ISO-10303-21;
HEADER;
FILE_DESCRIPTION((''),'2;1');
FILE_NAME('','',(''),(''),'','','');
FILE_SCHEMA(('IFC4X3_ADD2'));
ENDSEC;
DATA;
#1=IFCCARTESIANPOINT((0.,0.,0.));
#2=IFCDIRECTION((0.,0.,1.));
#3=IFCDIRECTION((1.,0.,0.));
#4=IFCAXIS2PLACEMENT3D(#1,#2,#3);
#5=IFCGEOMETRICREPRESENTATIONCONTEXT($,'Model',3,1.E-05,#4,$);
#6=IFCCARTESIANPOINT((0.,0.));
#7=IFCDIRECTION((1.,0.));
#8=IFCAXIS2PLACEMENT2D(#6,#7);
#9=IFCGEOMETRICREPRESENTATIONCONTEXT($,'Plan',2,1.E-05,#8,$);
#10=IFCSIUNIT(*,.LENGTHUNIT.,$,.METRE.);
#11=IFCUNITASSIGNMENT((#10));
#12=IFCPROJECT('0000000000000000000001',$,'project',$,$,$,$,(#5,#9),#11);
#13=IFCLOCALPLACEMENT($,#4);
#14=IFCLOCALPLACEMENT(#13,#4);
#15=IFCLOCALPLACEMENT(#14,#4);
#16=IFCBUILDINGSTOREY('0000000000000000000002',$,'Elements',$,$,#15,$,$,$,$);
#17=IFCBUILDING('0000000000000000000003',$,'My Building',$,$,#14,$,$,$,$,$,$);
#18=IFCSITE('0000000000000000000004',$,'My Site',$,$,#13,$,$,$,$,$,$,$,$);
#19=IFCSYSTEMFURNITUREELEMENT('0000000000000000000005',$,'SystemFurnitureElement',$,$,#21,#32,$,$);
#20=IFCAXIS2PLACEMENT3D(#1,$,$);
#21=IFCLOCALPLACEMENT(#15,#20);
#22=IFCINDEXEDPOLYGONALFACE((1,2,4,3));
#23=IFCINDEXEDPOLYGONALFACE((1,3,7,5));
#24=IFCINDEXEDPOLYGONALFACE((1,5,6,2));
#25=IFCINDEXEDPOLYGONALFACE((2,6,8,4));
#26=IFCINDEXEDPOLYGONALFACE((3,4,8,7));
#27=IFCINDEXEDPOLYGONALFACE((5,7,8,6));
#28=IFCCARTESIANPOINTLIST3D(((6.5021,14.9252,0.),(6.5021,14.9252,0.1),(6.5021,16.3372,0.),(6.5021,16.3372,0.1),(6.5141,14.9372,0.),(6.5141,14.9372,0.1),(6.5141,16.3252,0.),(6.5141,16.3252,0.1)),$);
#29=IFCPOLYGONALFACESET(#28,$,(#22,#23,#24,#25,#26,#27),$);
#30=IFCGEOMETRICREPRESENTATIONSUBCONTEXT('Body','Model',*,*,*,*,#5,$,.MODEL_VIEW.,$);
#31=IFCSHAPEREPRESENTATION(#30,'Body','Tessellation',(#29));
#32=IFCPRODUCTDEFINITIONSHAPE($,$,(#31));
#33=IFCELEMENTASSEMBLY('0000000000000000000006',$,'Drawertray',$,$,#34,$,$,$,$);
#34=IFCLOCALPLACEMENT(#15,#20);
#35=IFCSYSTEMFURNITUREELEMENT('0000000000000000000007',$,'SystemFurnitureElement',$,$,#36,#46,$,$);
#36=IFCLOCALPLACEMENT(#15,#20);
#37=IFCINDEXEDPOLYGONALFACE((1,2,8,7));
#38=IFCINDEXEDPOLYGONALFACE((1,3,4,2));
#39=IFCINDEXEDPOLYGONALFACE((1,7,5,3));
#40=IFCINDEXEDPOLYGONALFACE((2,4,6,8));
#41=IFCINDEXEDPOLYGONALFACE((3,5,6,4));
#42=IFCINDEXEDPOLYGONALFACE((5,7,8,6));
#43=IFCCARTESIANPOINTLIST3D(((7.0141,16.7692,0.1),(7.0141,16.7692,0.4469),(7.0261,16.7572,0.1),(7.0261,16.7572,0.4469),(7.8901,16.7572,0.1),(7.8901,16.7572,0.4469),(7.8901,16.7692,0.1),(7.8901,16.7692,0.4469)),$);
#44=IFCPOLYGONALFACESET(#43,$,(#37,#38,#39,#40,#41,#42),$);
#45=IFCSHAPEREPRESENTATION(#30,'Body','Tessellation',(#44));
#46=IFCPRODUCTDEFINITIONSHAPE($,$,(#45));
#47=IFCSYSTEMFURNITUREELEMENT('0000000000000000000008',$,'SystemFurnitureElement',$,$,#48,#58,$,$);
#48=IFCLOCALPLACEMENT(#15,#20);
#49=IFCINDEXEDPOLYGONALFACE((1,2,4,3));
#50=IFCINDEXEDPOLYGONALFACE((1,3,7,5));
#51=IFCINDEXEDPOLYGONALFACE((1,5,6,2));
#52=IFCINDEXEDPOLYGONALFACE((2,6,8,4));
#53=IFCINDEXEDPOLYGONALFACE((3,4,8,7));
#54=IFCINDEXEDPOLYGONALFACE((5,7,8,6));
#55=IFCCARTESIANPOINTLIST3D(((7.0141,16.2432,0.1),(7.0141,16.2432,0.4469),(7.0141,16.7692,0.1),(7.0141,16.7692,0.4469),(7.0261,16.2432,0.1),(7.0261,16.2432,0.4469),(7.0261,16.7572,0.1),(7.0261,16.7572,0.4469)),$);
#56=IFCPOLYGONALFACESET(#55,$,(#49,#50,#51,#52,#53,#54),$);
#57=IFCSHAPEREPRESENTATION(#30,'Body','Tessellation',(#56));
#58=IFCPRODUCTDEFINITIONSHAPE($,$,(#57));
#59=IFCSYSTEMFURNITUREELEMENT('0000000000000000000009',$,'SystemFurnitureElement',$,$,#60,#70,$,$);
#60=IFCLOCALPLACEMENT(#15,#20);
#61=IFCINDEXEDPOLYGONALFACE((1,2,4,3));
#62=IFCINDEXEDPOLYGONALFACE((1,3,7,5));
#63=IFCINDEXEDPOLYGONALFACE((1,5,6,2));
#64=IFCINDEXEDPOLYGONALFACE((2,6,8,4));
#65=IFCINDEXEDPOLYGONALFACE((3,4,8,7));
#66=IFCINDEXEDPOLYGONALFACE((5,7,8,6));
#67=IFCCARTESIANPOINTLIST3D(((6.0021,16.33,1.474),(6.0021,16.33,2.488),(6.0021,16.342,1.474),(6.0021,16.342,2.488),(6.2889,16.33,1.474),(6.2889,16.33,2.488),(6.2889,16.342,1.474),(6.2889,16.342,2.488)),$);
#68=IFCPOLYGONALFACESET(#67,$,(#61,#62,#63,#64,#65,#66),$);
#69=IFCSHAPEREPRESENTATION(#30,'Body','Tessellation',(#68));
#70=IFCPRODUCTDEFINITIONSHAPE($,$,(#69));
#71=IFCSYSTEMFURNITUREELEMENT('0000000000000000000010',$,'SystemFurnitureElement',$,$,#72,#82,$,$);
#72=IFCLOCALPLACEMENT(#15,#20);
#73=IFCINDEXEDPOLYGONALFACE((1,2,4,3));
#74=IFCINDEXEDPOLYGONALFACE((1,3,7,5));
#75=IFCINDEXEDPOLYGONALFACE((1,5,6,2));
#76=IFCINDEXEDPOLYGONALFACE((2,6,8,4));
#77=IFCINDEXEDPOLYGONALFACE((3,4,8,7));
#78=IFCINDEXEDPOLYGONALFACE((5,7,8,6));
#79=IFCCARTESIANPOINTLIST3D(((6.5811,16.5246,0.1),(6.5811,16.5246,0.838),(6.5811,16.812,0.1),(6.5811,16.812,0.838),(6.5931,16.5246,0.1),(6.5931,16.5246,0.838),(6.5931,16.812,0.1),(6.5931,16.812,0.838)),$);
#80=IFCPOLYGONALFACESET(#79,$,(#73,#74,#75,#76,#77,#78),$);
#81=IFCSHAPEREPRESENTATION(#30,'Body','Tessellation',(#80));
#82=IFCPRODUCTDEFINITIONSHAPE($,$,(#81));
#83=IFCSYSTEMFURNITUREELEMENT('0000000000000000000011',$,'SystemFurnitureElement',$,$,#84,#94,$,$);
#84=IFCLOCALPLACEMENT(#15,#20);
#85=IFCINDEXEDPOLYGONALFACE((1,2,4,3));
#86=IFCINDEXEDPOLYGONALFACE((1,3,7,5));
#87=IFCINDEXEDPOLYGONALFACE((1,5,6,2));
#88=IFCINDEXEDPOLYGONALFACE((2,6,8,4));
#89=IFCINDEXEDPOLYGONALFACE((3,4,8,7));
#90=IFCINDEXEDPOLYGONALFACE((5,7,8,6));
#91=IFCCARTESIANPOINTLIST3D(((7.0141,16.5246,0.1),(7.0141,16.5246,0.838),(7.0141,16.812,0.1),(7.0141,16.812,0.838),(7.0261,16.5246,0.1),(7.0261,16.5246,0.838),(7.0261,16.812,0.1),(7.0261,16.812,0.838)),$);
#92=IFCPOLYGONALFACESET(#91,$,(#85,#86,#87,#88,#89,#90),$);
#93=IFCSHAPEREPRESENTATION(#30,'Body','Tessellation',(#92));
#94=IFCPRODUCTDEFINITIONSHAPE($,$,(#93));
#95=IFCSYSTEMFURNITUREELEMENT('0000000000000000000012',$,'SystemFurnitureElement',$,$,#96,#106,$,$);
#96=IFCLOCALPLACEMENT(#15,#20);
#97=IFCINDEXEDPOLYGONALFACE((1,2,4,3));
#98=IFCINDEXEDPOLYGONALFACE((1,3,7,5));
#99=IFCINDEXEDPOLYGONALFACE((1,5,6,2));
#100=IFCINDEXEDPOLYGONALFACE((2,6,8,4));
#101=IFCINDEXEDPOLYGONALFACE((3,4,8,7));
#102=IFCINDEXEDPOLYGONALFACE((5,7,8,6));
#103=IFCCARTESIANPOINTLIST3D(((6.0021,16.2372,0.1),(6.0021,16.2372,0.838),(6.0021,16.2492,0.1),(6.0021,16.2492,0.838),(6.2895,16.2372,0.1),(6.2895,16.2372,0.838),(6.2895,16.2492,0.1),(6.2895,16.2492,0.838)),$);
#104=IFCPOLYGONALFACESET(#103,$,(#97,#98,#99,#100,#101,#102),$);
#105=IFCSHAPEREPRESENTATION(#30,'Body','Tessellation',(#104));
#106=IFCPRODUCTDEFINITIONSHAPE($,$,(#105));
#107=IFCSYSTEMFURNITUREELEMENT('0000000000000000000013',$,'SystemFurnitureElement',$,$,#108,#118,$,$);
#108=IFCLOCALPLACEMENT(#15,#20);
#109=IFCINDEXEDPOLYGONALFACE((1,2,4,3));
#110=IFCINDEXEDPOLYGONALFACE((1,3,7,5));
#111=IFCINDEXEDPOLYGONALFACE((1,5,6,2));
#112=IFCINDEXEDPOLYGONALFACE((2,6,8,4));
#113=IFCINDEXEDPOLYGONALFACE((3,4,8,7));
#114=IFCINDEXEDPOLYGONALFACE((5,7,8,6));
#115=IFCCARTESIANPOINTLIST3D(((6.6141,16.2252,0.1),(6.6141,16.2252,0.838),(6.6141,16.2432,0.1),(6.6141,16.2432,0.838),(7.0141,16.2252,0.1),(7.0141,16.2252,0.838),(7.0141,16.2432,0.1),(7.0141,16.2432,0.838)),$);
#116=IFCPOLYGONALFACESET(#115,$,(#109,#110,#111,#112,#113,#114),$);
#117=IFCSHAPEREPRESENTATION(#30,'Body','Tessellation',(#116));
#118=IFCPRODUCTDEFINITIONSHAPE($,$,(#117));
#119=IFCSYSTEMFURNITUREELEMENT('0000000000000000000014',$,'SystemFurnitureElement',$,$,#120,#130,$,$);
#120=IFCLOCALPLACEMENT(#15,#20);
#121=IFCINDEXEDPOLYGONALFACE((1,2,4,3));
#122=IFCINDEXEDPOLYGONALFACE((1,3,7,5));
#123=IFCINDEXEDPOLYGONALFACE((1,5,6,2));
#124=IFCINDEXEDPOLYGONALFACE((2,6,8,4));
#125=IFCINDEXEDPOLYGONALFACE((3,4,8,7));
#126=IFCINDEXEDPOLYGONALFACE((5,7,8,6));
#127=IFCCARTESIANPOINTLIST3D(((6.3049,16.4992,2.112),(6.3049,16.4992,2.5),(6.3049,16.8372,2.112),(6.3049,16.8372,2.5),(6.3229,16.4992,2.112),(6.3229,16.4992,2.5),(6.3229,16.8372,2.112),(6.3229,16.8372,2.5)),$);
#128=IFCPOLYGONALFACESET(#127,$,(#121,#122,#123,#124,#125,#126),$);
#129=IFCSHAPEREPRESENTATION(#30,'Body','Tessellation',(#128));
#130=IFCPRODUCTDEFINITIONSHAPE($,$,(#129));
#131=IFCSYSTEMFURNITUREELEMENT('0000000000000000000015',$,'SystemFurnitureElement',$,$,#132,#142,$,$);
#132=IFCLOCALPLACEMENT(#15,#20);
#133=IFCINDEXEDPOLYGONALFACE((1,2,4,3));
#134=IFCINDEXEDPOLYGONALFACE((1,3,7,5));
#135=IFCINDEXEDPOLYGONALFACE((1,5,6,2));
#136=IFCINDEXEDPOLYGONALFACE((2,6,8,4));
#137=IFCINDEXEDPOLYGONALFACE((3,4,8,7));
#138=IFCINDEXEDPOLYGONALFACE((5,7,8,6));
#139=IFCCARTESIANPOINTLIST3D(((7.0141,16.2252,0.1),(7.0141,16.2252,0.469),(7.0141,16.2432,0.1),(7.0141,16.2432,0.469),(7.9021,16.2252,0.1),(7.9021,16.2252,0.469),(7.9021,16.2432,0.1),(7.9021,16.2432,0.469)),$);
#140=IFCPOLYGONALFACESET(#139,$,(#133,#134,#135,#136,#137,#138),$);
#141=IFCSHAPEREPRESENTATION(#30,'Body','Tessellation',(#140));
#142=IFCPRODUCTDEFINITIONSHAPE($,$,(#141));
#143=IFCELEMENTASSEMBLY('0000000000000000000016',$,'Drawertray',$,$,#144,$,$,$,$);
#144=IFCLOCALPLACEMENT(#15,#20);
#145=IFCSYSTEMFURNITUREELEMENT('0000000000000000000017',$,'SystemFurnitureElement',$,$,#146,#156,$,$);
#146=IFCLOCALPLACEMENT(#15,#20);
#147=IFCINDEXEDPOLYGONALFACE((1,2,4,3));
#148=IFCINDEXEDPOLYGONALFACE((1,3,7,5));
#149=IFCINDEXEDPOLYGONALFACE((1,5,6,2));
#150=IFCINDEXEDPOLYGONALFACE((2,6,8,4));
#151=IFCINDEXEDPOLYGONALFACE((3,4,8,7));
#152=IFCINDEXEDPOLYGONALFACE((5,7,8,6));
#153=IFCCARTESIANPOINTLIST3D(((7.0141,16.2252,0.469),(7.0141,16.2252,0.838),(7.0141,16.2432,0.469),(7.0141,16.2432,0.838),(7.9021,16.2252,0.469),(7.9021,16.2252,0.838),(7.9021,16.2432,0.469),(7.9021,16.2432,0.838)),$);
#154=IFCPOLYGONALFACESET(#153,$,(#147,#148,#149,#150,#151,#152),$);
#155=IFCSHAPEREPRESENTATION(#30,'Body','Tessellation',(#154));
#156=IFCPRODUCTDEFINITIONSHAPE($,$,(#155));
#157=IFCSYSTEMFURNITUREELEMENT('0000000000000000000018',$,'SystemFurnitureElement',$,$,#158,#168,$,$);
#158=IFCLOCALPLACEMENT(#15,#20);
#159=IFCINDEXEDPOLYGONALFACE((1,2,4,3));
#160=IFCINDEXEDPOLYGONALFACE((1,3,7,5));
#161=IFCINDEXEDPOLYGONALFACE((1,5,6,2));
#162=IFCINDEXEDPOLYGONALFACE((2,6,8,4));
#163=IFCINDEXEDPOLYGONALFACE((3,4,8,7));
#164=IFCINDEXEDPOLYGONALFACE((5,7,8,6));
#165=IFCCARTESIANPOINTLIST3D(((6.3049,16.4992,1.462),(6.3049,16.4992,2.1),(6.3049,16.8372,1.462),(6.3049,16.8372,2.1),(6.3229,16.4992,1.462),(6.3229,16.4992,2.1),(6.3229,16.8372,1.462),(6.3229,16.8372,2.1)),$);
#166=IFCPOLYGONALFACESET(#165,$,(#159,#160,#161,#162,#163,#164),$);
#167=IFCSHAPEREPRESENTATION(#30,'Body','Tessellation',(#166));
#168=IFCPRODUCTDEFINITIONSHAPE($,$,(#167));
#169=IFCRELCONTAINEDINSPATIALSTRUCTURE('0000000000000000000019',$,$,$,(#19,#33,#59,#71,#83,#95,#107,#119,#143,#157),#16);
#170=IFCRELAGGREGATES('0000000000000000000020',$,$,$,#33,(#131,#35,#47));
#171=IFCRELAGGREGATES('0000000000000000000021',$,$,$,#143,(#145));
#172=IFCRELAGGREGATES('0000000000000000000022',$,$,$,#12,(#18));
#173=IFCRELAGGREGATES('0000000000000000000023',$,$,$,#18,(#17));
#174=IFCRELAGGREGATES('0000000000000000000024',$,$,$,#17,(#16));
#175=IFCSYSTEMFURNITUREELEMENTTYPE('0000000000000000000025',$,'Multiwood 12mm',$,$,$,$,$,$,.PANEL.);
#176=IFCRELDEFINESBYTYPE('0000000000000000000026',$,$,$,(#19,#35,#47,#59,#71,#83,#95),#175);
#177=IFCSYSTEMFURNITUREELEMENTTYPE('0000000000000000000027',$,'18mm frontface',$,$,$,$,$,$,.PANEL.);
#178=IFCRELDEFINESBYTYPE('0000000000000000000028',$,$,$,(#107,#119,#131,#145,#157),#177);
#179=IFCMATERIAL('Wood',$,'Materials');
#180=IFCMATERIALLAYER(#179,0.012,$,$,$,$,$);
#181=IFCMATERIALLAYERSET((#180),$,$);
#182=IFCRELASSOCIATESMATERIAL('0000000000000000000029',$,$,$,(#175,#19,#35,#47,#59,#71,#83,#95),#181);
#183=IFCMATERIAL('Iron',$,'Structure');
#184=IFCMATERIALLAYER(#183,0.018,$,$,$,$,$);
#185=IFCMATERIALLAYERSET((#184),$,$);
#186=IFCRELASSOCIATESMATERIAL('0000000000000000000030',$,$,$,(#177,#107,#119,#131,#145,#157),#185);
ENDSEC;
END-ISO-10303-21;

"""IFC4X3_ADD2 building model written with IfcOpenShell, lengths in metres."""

from ifc_helpers import new_model, si_unit, frame, origin_with_axes, origin_2d_with_axis, place, context, subcontext, project, spatial, line, indexed_curve, outline, extrude, material, layer, layer_set, layer_usage, type_object, element, aggregate, save


model = new_model("IFC4X3_ADD2")

# Units and contexts
model_context = context("Model", 3, precision=1e-05, world=origin_with_axes())
plan_context = context("Plan", 2, precision=1e-05, world=origin_2d_with_axis())
body_context = subcontext(model_context, "Body", "Model", "MODEL_VIEW")
ifc_project = project(units=[si_unit("LENGTHUNIT", "METRE")], contexts=[model_context, plan_context])

# Site, building, storey
site_placement = place(None, origin_with_axes())
site = spatial("IfcSite", under=ifc_project, at=site_placement, Name="My Site")
building_placement = place(site_placement, origin_with_axes())
building = spatial("IfcBuilding", under=site, at=building_placement, Name="My Building")
storey_placement = place(building_placement, origin_with_axes())
storey = spatial("IfcBuildingStorey", under=building, at=storey_placement, Name="Elements")

# System furniture element
ifc_material_1 = material(Name="Wood", Category="Materials")
ifc_layer_1 = layer(ifc_material_1, 0.012)
ifc_layer_set_1 = layer_set([ifc_layer_1])
ifc_layer_usage_1 = layer_usage(ifc_layer_set_1, "AXIS2", "POSITIVE", 0.0)
system_furniture_element_type_1 = type_object("IfcSystemFurnitureElementType", Name="Multiwood 12mm", PredefinedType="PANEL", material=ifc_layer_set_1)
system_furniture_element_1_placement = place(storey_placement, frame((6.5021, 16.3372, 0.0), z_axis=(0.0, 0.0, 1.0), x_axis=(0.0, -1.0, 0.0)))
element("IfcSystemFurnitureElement", 1, at=system_furniture_element_1_placement, inside=storey, type_object=system_furniture_element_type_1, material=ifc_layer_usage_1, Name="SystemFurnitureElement", context=body_context, shape_type="SweptSolid", body=[
    extrude(outline(indexed_curve([(0.0, 0.0), (0.012, 0.012), (1.4, 0.012), (1.412, 0.0)], segments=[line(1, 2, 3, 4, 1)])), origin_with_axes(), (0.0, 0.0, 1.0), 0.1),
])

# Element assembly, system furniture elements
assembly_1_placement = place(storey_placement, frame((7.0141, 16.2252, 0.1), z_axis=(0.0, 0.0, 1.0), x_axis=(-1.0, 0.0, 0.0)))
assembly_1 = element("IfcElementAssembly", 2, at=assembly_1_placement, inside=storey, Name="Drawertray")
ifc_layer_usage_2 = layer_usage(ifc_layer_set_1, "AXIS2", "POSITIVE", 0.0)
system_furniture_element_2_placement = place(assembly_1_placement, frame((0.0, -0.532, 0.0), z_axis=(0.0, 0.0, 1.0), x_axis=(-1.0, 0.0, 0.0)))
system_furniture_element_2 = element("IfcSystemFurnitureElement", 3, at=system_furniture_element_2_placement, type_object=system_furniture_element_type_1, material=ifc_layer_usage_2, Name="SystemFurnitureElement", context=body_context, shape_type="SweptSolid", body=[
    extrude(outline(indexed_curve([(0.012, 0.0), (0.0, 0.012), (0.876, 0.012), (0.876, 0.0)], segments=[line(1, 2, 3, 4, 1)])), origin_with_axes(), (0.0, 0.0, 1.0), 0.3469),
])
ifc_layer_usage_3 = layer_usage(ifc_layer_set_1, "AXIS2", "POSITIVE", 0.0)
system_furniture_element_3_placement = place(assembly_1_placement, frame((0.0, -0.532, 0.0), z_axis=(0.0, 0.0, 1.0), x_axis=(0.000001, 1.0, 0.0)))
system_furniture_element_3 = element("IfcSystemFurnitureElement", 4, at=system_furniture_element_3_placement, type_object=system_furniture_element_type_1, material=ifc_layer_usage_3, Name="SystemFurnitureElement", context=body_context, shape_type="SweptSolid", body=[
    extrude(outline(indexed_curve([(-0.012, 0.0), (0.0, 0.012), (0.514, 0.012), (0.514, 0.0)], segments=[line(1, 2, 3, 4, 1)])), origin_with_axes(), (0.0, 0.0, 1.0), 0.3469),
])

# System furniture elements
ifc_layer_usage_4 = layer_usage(ifc_layer_set_1, "AXIS2", "NEGATIVE", 0.0)
system_furniture_element_4_placement = place(storey_placement, frame((6.2889, 16.33, 1.474), z_axis=(0.0, 0.0, 1.0), x_axis=(-1.0, 0.0, 0.0)))
element("IfcSystemFurnitureElement", 5, at=system_furniture_element_4_placement, inside=storey, type_object=system_furniture_element_type_1, material=ifc_layer_usage_4, Name="SystemFurnitureElement", context=body_context, shape_type="SweptSolid", body=[
    extrude(outline(indexed_curve([(0.0, -0.012), (0.0, 0.0), (0.2869, 0.0), (0.2869, -0.012)], segments=[line(1, 2, 3, 4, 1)])), origin_with_axes(), (0.0, 0.0, 1.0), 1.014),
])
ifc_layer_usage_5 = layer_usage(ifc_layer_set_1, "AXIS2", "POSITIVE", 0.0)
system_furniture_element_5_placement = place(storey_placement, frame((6.5811, 16.812, 0.1), z_axis=(0.0, 0.0, 1.0), x_axis=(0.0, -1.0, 0.0)))
element("IfcSystemFurnitureElement", 6, at=system_furniture_element_5_placement, inside=storey, type_object=system_furniture_element_type_1, material=ifc_layer_usage_5, Name="SystemFurnitureElement", context=body_context, shape_type="SweptSolid", body=[
    extrude(outline(indexed_curve([(0.0, 0.0), (0.0, 0.012), (0.2874, 0.012), (0.2874, 0.0)], segments=[line(1, 2, 3, 4, 1)])), origin_with_axes(), (0.0, 0.0, 1.0), 0.738),
])
ifc_layer_usage_6 = layer_usage(ifc_layer_set_1, "AXIS2", "POSITIVE", 0.0)
system_furniture_element_6_placement = place(storey_placement, frame((7.0141, 16.812, 0.1), z_axis=(0.0, 0.0, 1.0), x_axis=(0.0, -1.0, 0.0)))
element("IfcSystemFurnitureElement", 7, at=system_furniture_element_6_placement, inside=storey, type_object=system_furniture_element_type_1, material=ifc_layer_usage_6, Name="SystemFurnitureElement", context=body_context, shape_type="SweptSolid", body=[
    extrude(outline(indexed_curve([(0.0, 0.0), (0.0, 0.012), (0.2874, 0.012), (0.2874, 0.0)], segments=[line(1, 2, 3, 4, 1)])), origin_with_axes(), (0.0, 0.0, 1.0), 0.738),
])
ifc_layer_usage_7 = layer_usage(ifc_layer_set_1, "AXIS2", "POSITIVE", 0.0)
system_furniture_element_7_placement = place(storey_placement, frame((6.0021, 16.2372, 0.1), z_axis=(0.0, 0.0, 1.0), x_axis=(1.0, 0.0, 0.0)))
element("IfcSystemFurnitureElement", 8, at=system_furniture_element_7_placement, inside=storey, type_object=system_furniture_element_type_1, material=ifc_layer_usage_7, Name="SystemFurnitureElement", context=body_context, shape_type="SweptSolid", body=[
    extrude(outline(indexed_curve([(0.0, 0.0), (0.0, 0.012), (0.2874, 0.012), (0.2874, 0.0)], segments=[line(1, 2, 3, 4, 1)])), origin_with_axes(), (0.0, 0.0, 1.0), 0.738),
])
ifc_material_2 = material(Name="Iron", Category="Structure")
ifc_layer_2 = layer(ifc_material_2, 0.018)
ifc_layer_set_2 = layer_set([ifc_layer_2])
ifc_layer_usage_8 = layer_usage(ifc_layer_set_2, "AXIS2", "POSITIVE", 0.0)
system_furniture_element_type_2 = type_object("IfcSystemFurnitureElementType", Name="18mm frontface", PredefinedType="PANEL", material=ifc_layer_set_2)
system_furniture_element_8_placement = place(storey_placement, frame((7.0141, 16.2432, 0.1), z_axis=(0.0, 0.0, 1.0), x_axis=(-1.0, 0.0, 0.0)))
element("IfcSystemFurnitureElement", 9, at=system_furniture_element_8_placement, inside=storey, type_object=system_furniture_element_type_2, material=ifc_layer_usage_8, Name="SystemFurnitureElement", context=body_context, shape_type="SweptSolid", body=[
    extrude(outline(indexed_curve([(0.0, 0.0), (0.0, 0.018), (0.4, 0.018), (0.4, 0.0)], segments=[line(1, 2, 3, 4, 1)])), origin_with_axes(), (0.0, 0.0, 1.0), 0.738),
])
ifc_layer_usage_9 = layer_usage(ifc_layer_set_2, "AXIS2", "POSITIVE", 0.0)
system_furniture_element_9_placement = place(storey_placement, frame((6.3049, 16.8372, 2.112), z_axis=(0.0, 0.0, 1.0), x_axis=(0.0, -1.0, 0.0)))
element("IfcSystemFurnitureElement", 10, at=system_furniture_element_9_placement, inside=storey, type_object=system_furniture_element_type_2, material=ifc_layer_usage_9, Name="SystemFurnitureElement", context=body_context, shape_type="SweptSolid", body=[
    extrude(outline(indexed_curve([(0.0, 0.0), (0.0, 0.018), (0.338, 0.018), (0.338, 0.0)], segments=[line(1, 2, 3, 4, 1)])), origin_with_axes(), (0.0, 0.0, 1.0), 0.388),
])

# System furniture element
ifc_layer_usage_10 = layer_usage(ifc_layer_set_2, "AXIS2", "POSITIVE", 0.0)
system_furniture_element_10_placement = place(assembly_1_placement, frame((0.0, 0.0, 0.0), z_axis=(0.0, 0.0, 1.0), x_axis=(-1.0, 0.0, 0.0)))
system_furniture_element_10 = element("IfcSystemFurnitureElement", 11, at=system_furniture_element_10_placement, type_object=system_furniture_element_type_2, material=ifc_layer_usage_10, Name="SystemFurnitureElement", context=body_context, shape_type="SweptSolid", body=[
    extrude(outline(indexed_curve([(0.0, 0.0), (0.0, 0.018), (0.888, 0.018), (0.888, 0.0)], segments=[line(1, 2, 3, 4, 1)])), origin_with_axes(), (0.0, 0.0, 1.0), 0.369),
])
aggregate(assembly_1, [system_furniture_element_10, system_furniture_element_2, system_furniture_element_3])

# Element assembly, system furniture element
assembly_2_placement = place(storey_placement, frame((7.0141, 16.2252, 0.469), z_axis=(0.0, 0.0, 1.0), x_axis=(-1.0, 0.0, 0.0)))
assembly_2 = element("IfcElementAssembly", 12, at=assembly_2_placement, inside=storey, Name="Drawertray")
ifc_layer_usage_11 = layer_usage(ifc_layer_set_2, "AXIS2", "POSITIVE", 0.0)
system_furniture_element_11_placement = place(assembly_2_placement, frame((0.0, 0.0, 0.0), z_axis=(0.0, 0.0, 1.0), x_axis=(-1.0, 0.0, 0.0)))
system_furniture_element_11 = element("IfcSystemFurnitureElement", 13, at=system_furniture_element_11_placement, type_object=system_furniture_element_type_2, material=ifc_layer_usage_11, Name="SystemFurnitureElement", context=body_context, shape_type="SweptSolid", body=[
    extrude(outline(indexed_curve([(0.0, 0.0), (0.0, 0.018), (0.888, 0.018), (0.888, 0.0)], segments=[line(1, 2, 3, 4, 1)])), origin_with_axes(), (0.0, 0.0, 1.0), 0.369),
])
aggregate(assembly_2, [system_furniture_element_11])

# System furniture element
ifc_layer_usage_12 = layer_usage(ifc_layer_set_2, "AXIS2", "POSITIVE", 0.0)
system_furniture_element_12_placement = place(storey_placement, frame((6.3049, 16.8372, 1.462), z_axis=(0.0, 0.0, 1.0), x_axis=(0.0, -1.0, 0.0)))
element("IfcSystemFurnitureElement", 14, at=system_furniture_element_12_placement, inside=storey, type_object=system_furniture_element_type_2, material=ifc_layer_usage_12, Name="SystemFurnitureElement", context=body_context, shape_type="SweptSolid", body=[
    extrude(outline(indexed_curve([(0.0, 0.0), (0.0, 0.018), (0.338, 0.018), (0.338, 0.0)], segments=[line(1, 2, 3, 4, 1)])), origin_with_axes(), (0.0, 0.0, 1.0), 0.638),
])

save(model, "model.ifc")
